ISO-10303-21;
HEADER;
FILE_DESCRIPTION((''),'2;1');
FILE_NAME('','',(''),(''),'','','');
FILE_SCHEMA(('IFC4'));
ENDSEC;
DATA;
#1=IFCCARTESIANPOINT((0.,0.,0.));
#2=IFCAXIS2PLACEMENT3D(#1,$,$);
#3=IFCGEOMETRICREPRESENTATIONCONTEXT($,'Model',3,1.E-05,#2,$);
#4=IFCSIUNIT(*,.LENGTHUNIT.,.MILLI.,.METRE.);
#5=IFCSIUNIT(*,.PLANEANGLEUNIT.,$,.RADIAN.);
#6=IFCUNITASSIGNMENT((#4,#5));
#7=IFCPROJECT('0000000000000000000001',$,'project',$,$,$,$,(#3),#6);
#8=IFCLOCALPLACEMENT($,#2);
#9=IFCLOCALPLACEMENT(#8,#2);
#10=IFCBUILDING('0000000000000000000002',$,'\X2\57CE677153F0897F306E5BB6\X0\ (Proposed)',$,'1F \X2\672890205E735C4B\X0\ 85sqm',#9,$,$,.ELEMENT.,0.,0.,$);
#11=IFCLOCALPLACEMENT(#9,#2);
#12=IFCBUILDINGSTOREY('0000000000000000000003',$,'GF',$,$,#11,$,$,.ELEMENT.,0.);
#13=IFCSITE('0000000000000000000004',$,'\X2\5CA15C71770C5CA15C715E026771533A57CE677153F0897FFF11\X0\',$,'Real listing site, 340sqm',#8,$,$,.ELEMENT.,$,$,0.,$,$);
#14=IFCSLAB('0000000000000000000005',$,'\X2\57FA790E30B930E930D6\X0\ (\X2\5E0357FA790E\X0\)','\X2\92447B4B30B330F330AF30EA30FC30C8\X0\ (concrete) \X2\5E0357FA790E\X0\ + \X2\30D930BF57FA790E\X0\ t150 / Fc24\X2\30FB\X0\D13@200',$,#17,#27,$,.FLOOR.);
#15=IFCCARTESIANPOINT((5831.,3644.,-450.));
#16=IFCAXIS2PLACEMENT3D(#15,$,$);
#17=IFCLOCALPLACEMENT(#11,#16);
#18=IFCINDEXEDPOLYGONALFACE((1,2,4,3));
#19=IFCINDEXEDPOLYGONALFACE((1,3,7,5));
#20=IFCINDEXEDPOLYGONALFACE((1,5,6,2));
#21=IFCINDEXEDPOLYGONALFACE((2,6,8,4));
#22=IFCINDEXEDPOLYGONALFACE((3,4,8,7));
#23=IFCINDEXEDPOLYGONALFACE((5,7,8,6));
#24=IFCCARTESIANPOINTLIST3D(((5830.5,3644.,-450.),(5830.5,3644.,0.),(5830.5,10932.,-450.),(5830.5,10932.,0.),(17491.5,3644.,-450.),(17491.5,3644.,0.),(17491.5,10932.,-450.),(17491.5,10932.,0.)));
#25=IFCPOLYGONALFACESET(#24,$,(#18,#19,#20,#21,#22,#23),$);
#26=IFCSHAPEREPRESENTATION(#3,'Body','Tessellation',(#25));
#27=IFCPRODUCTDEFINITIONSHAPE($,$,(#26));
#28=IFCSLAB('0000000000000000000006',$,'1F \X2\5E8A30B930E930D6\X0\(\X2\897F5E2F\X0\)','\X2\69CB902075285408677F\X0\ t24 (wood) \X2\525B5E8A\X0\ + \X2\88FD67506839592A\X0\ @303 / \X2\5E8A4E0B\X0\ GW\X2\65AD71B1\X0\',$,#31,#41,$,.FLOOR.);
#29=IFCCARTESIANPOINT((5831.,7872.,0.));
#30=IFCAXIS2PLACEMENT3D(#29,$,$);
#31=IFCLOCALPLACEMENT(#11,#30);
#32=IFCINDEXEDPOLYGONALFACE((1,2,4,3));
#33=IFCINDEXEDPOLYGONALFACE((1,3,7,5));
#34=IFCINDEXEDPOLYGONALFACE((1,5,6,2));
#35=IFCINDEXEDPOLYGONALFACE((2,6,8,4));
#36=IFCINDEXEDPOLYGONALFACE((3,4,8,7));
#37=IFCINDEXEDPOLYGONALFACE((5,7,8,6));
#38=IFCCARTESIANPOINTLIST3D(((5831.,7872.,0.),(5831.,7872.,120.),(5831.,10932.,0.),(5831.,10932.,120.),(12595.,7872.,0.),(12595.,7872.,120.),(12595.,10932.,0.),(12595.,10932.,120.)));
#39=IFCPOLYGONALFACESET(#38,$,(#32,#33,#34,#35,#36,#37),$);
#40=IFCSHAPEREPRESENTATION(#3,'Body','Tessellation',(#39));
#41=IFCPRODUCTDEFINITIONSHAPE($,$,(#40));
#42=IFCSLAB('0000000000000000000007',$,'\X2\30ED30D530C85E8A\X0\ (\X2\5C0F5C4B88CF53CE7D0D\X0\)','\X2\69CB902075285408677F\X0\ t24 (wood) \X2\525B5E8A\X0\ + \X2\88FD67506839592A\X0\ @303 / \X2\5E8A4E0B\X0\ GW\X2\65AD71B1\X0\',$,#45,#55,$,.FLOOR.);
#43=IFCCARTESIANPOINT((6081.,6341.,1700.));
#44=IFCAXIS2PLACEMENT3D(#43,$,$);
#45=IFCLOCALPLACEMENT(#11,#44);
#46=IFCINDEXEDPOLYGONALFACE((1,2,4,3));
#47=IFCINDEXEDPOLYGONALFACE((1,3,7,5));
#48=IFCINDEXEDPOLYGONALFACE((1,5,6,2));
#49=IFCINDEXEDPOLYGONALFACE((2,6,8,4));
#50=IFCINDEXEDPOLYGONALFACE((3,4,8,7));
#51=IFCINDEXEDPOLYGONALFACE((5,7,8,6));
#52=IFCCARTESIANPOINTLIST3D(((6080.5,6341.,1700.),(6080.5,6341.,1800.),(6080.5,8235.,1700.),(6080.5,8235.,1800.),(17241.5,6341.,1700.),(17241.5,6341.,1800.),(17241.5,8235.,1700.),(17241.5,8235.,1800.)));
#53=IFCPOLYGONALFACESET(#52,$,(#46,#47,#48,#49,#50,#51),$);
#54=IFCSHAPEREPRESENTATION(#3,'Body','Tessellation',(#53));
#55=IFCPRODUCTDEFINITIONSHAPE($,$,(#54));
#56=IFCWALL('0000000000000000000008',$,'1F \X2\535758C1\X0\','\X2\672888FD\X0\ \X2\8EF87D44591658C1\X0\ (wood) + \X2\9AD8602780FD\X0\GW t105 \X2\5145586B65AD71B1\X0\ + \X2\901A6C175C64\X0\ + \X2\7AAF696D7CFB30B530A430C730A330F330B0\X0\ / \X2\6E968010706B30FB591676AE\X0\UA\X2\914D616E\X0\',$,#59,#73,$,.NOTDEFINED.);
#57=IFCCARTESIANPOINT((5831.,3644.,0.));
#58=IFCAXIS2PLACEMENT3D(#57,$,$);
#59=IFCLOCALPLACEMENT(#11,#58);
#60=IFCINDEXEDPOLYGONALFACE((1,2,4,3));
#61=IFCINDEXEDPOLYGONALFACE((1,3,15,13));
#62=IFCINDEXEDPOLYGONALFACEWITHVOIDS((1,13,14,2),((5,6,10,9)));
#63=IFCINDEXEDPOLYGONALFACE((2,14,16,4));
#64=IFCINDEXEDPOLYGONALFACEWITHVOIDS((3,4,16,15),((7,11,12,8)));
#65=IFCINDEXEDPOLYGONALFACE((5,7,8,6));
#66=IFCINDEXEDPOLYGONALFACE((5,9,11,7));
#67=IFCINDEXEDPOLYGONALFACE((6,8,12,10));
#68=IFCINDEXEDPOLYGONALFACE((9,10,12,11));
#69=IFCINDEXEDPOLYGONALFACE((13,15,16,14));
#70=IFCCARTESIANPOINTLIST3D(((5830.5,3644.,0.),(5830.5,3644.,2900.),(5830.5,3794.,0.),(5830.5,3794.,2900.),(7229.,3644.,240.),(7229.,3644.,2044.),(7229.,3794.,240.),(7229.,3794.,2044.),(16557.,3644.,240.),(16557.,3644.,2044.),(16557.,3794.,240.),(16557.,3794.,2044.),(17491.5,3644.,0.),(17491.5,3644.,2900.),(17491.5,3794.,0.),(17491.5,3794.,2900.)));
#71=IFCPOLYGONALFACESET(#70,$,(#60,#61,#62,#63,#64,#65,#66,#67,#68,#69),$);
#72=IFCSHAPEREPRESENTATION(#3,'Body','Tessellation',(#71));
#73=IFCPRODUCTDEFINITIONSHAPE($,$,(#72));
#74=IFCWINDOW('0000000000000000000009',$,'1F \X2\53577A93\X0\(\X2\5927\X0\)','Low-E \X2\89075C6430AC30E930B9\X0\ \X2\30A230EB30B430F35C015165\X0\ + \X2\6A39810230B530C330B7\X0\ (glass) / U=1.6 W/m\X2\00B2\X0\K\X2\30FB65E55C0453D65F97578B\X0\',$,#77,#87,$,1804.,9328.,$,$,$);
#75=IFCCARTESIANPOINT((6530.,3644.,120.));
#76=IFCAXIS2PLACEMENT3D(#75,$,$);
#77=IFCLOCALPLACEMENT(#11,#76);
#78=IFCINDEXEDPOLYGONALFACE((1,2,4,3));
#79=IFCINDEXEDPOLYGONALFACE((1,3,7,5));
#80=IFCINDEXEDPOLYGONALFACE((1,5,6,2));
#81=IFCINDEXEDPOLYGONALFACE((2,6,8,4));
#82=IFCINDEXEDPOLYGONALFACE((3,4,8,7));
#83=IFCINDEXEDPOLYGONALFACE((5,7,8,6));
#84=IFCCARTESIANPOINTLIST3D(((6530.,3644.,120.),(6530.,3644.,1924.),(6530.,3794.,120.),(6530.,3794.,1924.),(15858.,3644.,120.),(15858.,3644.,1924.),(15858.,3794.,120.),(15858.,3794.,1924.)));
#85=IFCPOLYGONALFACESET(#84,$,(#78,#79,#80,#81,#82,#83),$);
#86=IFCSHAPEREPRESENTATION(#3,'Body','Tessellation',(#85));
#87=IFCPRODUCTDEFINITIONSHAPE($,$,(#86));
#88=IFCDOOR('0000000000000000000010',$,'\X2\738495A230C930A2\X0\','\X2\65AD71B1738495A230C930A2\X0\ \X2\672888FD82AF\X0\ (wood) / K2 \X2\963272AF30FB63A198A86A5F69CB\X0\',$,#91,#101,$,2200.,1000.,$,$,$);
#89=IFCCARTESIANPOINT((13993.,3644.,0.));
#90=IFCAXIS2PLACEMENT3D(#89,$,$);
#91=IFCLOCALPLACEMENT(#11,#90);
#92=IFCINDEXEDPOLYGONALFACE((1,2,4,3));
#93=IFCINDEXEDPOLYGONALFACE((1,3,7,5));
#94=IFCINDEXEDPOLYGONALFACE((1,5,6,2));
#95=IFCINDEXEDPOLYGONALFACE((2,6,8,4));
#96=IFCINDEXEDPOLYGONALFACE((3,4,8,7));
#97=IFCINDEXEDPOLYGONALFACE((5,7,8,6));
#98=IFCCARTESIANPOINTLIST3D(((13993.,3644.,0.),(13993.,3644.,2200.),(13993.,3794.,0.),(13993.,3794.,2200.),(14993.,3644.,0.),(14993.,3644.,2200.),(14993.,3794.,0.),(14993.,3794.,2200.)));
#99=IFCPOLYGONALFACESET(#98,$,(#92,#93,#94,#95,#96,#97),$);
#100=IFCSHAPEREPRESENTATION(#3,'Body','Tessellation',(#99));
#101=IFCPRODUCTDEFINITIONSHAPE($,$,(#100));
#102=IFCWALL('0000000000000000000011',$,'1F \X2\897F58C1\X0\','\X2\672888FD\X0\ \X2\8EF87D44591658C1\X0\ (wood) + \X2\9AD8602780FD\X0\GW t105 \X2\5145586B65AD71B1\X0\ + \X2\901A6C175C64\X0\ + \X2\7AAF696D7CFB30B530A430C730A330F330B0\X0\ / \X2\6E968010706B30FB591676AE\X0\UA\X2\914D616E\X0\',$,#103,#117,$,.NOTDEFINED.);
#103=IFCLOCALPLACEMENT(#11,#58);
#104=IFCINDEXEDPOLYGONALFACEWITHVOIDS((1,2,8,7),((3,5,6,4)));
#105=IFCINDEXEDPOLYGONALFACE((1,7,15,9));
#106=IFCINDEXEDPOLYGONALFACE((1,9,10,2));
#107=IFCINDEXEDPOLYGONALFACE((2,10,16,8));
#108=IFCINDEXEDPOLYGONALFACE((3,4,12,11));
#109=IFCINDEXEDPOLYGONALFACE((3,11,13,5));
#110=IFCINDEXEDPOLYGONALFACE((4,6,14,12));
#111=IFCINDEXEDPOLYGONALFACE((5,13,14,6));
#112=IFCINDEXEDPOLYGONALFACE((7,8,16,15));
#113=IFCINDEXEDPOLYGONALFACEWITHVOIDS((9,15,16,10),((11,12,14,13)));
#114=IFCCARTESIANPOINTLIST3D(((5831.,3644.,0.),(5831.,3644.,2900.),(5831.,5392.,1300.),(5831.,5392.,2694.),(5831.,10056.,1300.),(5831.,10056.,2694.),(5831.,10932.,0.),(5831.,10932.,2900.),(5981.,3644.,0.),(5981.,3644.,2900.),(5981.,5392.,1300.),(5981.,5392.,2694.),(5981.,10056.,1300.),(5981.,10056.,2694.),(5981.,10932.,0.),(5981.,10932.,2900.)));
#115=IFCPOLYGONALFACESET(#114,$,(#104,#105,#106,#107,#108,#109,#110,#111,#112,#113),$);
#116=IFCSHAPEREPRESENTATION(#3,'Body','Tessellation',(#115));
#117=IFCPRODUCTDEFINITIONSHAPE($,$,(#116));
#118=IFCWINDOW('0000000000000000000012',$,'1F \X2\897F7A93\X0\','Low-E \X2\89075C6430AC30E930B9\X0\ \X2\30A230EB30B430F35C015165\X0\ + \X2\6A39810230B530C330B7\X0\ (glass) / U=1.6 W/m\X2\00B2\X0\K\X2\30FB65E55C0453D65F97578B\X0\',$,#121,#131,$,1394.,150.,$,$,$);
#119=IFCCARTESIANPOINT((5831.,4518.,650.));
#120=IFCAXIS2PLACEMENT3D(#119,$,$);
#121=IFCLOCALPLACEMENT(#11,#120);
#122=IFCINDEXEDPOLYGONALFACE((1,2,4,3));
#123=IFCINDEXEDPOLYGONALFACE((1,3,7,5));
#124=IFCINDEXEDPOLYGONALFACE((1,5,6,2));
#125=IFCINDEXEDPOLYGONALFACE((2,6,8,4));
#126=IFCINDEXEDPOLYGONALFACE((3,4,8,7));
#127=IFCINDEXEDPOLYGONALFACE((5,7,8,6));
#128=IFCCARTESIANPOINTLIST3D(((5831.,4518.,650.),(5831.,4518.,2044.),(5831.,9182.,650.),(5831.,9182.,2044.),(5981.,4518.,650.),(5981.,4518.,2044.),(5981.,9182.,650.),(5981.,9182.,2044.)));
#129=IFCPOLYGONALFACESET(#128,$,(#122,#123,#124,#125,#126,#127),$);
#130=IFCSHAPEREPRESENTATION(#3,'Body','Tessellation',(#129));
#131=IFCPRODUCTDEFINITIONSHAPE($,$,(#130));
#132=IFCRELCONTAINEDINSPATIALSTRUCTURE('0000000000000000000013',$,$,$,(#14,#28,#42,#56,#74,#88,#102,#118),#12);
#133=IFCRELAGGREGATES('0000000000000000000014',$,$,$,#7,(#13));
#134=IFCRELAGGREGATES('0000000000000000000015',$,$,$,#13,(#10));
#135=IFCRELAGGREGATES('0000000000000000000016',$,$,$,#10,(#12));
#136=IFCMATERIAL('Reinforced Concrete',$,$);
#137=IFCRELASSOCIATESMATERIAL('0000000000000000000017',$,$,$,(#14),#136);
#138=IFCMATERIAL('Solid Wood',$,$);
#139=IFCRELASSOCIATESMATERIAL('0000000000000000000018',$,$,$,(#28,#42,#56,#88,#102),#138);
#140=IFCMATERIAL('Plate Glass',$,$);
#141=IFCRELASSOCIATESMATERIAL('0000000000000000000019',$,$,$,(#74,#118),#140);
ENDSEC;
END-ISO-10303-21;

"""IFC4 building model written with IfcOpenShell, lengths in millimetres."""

from ifc_helpers import new_model, si_unit, frame, frame_2d, origin, place, context, project, spatial, rectangle, extrude, material, element, fill, save


model = new_model("IFC4")

# Units and contexts
model_context = context("Model", 3, precision=1e-05, world=origin())
ifc_project = project(units=[si_unit("LENGTHUNIT", "METRE", prefix="MILLI"), si_unit("PLANEANGLEUNIT", "RADIAN")], contexts=[model_context])

# Site, building, storey
site_placement = place(None, origin())
site = spatial("IfcSite", under=ifc_project, at=site_placement, Name="岡山県岡山市東区城東台西１", ObjectType="Real listing site, 340sqm", CompositionType="ELEMENT", RefElevation=0.0)
building_placement = place(site_placement, origin())
building = spatial("IfcBuilding", under=site, at=building_placement, Name="城東台西の家 (Proposed)", ObjectType="1F 木造平屋 85sqm", CompositionType="ELEMENT", ElevationOfRefHeight=0.0, ElevationOfTerrain=0.0)
storey_placement = place(building_placement, origin())
storey = spatial("IfcBuildingStorey", under=building, at=storey_placement, Name="GF", CompositionType="ELEMENT", Elevation=0.0)

# Slabs
ifc_material_1 = material(Name="Reinforced Concrete")
slab_1_placement = place(storey_placement, frame((5831.0, 3644.0, -450.0)))
element("IfcSlab", 1, at=slab_1_placement, inside=storey, material=ifc_material_1, Name="基礎スラブ (布基礎)", Description="鉄筋コンクリート (concrete) 布基礎 + ベタ基礎 t150 / Fc24・D13@200", PredefinedType="FLOOR", context=model_context, shape_type="SweptSolid", body=[
    extrude(rectangle(XDim=11661.0, YDim=7288.0, at=frame_2d((5830.0, 3644.0))), frame((5831.0, 3644.0, -450.0)), (0.0, 0.0, 1.0), 450.0),
])
ifc_material_2 = material(Name="Solid Wood")
slab_2_placement = place(storey_placement, frame((5831.0, 7872.0, 0.0)))
element("IfcSlab", 2, at=slab_2_placement, inside=storey, material=ifc_material_2, Name="1F 床スラブ(西帯)", Description="構造用合板 t24 (wood) 剛床 + 製材根太 @303 / 床下 GW断熱", PredefinedType="FLOOR", context=model_context, shape_type="SweptSolid", body=[
    extrude(rectangle(XDim=6764.0, YDim=3060.0, at=frame_2d((3382.0, 1530.0))), frame((5831.0, 7872.0, 0.0)), (0.0, 0.0, 1.0), 120.0),
])
slab_3_placement = place(storey_placement, frame((6081.0, 6341.0, 1700.0)))
element("IfcSlab", 3, at=slab_3_placement, inside=storey, material=ifc_material_2, Name="ロフト床 (小屋裏収納)", Description="構造用合板 t24 (wood) 剛床 + 製材根太 @303 / 床下 GW断熱", PredefinedType="FLOOR", context=model_context, shape_type="SweptSolid", body=[
    extrude(rectangle(XDim=11161.0, YDim=1894.0, at=frame_2d((5580.0, 947.0))), frame((6081.0, 6341.0, 1700.0)), (0.0, 0.0, 1.0), 100.0),
])

# Wall, openings, window, door
wall_1_placement = place(storey_placement, frame((5831.0, 3644.0, 0.0)))
wall_1 = element("IfcWall", 4, at=wall_1_placement, inside=storey, material=ifc_material_2, Name="1F 南壁", Description="木製 軸組外壁 (wood) + 高性能GW t105 充填断熱 + 通気層 + 窯業系サイディング / 準耐火・外皮UA配慮", PredefinedType="NOTDEFINED", context=model_context, shape_type="SweptSolid", body=[
    extrude(rectangle(XDim=11661.0, YDim=150.0, at=frame_2d((5830.0, 75.0))), frame((5831.0, 3644.0, 0.0)), (0.0, 0.0, 1.0), 2900.0),
])
opening_1_placement = place(storey_placement, frame((6530.0, 3644.0, 120.0)))
opening_1 = element("IfcOpeningElement", 5, at=opening_1_placement, cuts=wall_1, PredefinedType="NOTDEFINED", context=model_context, shape_type="SweptSolid", body=[
    extrude(rectangle(XDim=9328.0, YDim=150.0, at=frame_2d((4664.0, 75.0))), frame((6530.0, 3644.0, 120.0)), (0.0, 0.0, 1.0), 1804.0),
])
opening_2_placement = place(storey_placement, frame((13993.0, 3644.0, 0.0)))
opening_2 = element("IfcOpeningElement", 6, at=opening_2_placement, cuts=wall_1, PredefinedType="NOTDEFINED", context=model_context, shape_type="SweptSolid", body=[
    extrude(rectangle(XDim=1000.0, YDim=150.0, at=frame_2d((500.0, 75.0))), frame((13993.0, 3644.0, 0.0)), (0.0, 0.0, 1.0), 2200.0),
])
ifc_material_3 = material(Name="Plate Glass")
window_1_placement = place(storey_placement, frame((6530.0, 3644.0, 120.0)))
window_1 = element("IfcWindow", 7, at=window_1_placement, inside=storey, material=ifc_material_3, Name="1F 南窓(大)", Description="Low-E 複層ガラス アルゴン封入 + 樹脂サッシ (glass) / U=1.6 W/m²K・日射取得型", OverallHeight=1804.0, OverallWidth=9328.0, context=model_context, shape_type="SweptSolid", body=[
    extrude(rectangle(XDim=9328.0, YDim=150.0, at=frame_2d((4664.0, 75.0))), frame((6530.0, 3644.0, 120.0)), (0.0, 0.0, 1.0), 1804.0),
])
fill(opening_1, window_1)
door_1_placement = place(storey_placement, frame((13993.0, 3644.0, 0.0)))
door_1 = element("IfcDoor", 8, at=door_1_placement, inside=storey, material=ifc_material_2, Name="玄関ドア", Description="断熱玄関ドア 木製芯 (wood) / K2 防犯・採風機構", OverallHeight=2200.0, OverallWidth=1000.0, context=model_context, shape_type="SweptSolid", body=[
    extrude(rectangle(XDim=1000.0, YDim=150.0, at=frame_2d((500.0, 75.0))), frame((13993.0, 3644.0, 0.0)), (0.0, 0.0, 1.0), 2200.0),
])
fill(opening_2, door_1)

# Wall, opening, window
wall_2_placement = place(storey_placement, frame((5831.0, 3644.0, 0.0)))
wall_2 = element("IfcWall", 9, at=wall_2_placement, inside=storey, material=ifc_material_2, Name="1F 西壁", Description="木製 軸組外壁 (wood) + 高性能GW t105 充填断熱 + 通気層 + 窯業系サイディング / 準耐火・外皮UA配慮", PredefinedType="NOTDEFINED", context=model_context, shape_type="SweptSolid", body=[
    extrude(rectangle(XDim=150.0, YDim=7288.0, at=frame_2d((75.0, 3644.0))), frame((5831.0, 3644.0, 0.0)), (0.0, 0.0, 1.0), 2900.0),
])
opening_3_placement = place(storey_placement, frame((5831.0, 4518.0, 650.0)))
opening_3 = element("IfcOpeningElement", 10, at=opening_3_placement, cuts=wall_2, PredefinedType="NOTDEFINED", context=model_context, shape_type="SweptSolid", body=[
    extrude(rectangle(XDim=150.0, YDim=4664.0, at=frame_2d((75.0, 2332.0))), frame((5831.0, 4518.0, 650.0)), (0.0, 0.0, 1.0), 1394.0),
])
window_2_placement = place(storey_placement, frame((5831.0, 4518.0, 650.0)))
window_2 = element("IfcWindow", 11, at=window_2_placement, inside=storey, material=ifc_material_3, Name="1F 西窓", Description="Low-E 複層ガラス アルゴン封入 + 樹脂サッシ (glass) / U=1.6 W/m²K・日射取得型", OverallHeight=1394.0, OverallWidth=150.0, context=model_context, shape_type="SweptSolid", body=[
    extrude(rectangle(XDim=150.0, YDim=4664.0, at=frame_2d((75.0, 2332.0))), frame((5831.0, 4518.0, 650.0)), (0.0, 0.0, 1.0), 1394.0),
])
fill(opening_3, window_2)

save(model, "model.ifc")
